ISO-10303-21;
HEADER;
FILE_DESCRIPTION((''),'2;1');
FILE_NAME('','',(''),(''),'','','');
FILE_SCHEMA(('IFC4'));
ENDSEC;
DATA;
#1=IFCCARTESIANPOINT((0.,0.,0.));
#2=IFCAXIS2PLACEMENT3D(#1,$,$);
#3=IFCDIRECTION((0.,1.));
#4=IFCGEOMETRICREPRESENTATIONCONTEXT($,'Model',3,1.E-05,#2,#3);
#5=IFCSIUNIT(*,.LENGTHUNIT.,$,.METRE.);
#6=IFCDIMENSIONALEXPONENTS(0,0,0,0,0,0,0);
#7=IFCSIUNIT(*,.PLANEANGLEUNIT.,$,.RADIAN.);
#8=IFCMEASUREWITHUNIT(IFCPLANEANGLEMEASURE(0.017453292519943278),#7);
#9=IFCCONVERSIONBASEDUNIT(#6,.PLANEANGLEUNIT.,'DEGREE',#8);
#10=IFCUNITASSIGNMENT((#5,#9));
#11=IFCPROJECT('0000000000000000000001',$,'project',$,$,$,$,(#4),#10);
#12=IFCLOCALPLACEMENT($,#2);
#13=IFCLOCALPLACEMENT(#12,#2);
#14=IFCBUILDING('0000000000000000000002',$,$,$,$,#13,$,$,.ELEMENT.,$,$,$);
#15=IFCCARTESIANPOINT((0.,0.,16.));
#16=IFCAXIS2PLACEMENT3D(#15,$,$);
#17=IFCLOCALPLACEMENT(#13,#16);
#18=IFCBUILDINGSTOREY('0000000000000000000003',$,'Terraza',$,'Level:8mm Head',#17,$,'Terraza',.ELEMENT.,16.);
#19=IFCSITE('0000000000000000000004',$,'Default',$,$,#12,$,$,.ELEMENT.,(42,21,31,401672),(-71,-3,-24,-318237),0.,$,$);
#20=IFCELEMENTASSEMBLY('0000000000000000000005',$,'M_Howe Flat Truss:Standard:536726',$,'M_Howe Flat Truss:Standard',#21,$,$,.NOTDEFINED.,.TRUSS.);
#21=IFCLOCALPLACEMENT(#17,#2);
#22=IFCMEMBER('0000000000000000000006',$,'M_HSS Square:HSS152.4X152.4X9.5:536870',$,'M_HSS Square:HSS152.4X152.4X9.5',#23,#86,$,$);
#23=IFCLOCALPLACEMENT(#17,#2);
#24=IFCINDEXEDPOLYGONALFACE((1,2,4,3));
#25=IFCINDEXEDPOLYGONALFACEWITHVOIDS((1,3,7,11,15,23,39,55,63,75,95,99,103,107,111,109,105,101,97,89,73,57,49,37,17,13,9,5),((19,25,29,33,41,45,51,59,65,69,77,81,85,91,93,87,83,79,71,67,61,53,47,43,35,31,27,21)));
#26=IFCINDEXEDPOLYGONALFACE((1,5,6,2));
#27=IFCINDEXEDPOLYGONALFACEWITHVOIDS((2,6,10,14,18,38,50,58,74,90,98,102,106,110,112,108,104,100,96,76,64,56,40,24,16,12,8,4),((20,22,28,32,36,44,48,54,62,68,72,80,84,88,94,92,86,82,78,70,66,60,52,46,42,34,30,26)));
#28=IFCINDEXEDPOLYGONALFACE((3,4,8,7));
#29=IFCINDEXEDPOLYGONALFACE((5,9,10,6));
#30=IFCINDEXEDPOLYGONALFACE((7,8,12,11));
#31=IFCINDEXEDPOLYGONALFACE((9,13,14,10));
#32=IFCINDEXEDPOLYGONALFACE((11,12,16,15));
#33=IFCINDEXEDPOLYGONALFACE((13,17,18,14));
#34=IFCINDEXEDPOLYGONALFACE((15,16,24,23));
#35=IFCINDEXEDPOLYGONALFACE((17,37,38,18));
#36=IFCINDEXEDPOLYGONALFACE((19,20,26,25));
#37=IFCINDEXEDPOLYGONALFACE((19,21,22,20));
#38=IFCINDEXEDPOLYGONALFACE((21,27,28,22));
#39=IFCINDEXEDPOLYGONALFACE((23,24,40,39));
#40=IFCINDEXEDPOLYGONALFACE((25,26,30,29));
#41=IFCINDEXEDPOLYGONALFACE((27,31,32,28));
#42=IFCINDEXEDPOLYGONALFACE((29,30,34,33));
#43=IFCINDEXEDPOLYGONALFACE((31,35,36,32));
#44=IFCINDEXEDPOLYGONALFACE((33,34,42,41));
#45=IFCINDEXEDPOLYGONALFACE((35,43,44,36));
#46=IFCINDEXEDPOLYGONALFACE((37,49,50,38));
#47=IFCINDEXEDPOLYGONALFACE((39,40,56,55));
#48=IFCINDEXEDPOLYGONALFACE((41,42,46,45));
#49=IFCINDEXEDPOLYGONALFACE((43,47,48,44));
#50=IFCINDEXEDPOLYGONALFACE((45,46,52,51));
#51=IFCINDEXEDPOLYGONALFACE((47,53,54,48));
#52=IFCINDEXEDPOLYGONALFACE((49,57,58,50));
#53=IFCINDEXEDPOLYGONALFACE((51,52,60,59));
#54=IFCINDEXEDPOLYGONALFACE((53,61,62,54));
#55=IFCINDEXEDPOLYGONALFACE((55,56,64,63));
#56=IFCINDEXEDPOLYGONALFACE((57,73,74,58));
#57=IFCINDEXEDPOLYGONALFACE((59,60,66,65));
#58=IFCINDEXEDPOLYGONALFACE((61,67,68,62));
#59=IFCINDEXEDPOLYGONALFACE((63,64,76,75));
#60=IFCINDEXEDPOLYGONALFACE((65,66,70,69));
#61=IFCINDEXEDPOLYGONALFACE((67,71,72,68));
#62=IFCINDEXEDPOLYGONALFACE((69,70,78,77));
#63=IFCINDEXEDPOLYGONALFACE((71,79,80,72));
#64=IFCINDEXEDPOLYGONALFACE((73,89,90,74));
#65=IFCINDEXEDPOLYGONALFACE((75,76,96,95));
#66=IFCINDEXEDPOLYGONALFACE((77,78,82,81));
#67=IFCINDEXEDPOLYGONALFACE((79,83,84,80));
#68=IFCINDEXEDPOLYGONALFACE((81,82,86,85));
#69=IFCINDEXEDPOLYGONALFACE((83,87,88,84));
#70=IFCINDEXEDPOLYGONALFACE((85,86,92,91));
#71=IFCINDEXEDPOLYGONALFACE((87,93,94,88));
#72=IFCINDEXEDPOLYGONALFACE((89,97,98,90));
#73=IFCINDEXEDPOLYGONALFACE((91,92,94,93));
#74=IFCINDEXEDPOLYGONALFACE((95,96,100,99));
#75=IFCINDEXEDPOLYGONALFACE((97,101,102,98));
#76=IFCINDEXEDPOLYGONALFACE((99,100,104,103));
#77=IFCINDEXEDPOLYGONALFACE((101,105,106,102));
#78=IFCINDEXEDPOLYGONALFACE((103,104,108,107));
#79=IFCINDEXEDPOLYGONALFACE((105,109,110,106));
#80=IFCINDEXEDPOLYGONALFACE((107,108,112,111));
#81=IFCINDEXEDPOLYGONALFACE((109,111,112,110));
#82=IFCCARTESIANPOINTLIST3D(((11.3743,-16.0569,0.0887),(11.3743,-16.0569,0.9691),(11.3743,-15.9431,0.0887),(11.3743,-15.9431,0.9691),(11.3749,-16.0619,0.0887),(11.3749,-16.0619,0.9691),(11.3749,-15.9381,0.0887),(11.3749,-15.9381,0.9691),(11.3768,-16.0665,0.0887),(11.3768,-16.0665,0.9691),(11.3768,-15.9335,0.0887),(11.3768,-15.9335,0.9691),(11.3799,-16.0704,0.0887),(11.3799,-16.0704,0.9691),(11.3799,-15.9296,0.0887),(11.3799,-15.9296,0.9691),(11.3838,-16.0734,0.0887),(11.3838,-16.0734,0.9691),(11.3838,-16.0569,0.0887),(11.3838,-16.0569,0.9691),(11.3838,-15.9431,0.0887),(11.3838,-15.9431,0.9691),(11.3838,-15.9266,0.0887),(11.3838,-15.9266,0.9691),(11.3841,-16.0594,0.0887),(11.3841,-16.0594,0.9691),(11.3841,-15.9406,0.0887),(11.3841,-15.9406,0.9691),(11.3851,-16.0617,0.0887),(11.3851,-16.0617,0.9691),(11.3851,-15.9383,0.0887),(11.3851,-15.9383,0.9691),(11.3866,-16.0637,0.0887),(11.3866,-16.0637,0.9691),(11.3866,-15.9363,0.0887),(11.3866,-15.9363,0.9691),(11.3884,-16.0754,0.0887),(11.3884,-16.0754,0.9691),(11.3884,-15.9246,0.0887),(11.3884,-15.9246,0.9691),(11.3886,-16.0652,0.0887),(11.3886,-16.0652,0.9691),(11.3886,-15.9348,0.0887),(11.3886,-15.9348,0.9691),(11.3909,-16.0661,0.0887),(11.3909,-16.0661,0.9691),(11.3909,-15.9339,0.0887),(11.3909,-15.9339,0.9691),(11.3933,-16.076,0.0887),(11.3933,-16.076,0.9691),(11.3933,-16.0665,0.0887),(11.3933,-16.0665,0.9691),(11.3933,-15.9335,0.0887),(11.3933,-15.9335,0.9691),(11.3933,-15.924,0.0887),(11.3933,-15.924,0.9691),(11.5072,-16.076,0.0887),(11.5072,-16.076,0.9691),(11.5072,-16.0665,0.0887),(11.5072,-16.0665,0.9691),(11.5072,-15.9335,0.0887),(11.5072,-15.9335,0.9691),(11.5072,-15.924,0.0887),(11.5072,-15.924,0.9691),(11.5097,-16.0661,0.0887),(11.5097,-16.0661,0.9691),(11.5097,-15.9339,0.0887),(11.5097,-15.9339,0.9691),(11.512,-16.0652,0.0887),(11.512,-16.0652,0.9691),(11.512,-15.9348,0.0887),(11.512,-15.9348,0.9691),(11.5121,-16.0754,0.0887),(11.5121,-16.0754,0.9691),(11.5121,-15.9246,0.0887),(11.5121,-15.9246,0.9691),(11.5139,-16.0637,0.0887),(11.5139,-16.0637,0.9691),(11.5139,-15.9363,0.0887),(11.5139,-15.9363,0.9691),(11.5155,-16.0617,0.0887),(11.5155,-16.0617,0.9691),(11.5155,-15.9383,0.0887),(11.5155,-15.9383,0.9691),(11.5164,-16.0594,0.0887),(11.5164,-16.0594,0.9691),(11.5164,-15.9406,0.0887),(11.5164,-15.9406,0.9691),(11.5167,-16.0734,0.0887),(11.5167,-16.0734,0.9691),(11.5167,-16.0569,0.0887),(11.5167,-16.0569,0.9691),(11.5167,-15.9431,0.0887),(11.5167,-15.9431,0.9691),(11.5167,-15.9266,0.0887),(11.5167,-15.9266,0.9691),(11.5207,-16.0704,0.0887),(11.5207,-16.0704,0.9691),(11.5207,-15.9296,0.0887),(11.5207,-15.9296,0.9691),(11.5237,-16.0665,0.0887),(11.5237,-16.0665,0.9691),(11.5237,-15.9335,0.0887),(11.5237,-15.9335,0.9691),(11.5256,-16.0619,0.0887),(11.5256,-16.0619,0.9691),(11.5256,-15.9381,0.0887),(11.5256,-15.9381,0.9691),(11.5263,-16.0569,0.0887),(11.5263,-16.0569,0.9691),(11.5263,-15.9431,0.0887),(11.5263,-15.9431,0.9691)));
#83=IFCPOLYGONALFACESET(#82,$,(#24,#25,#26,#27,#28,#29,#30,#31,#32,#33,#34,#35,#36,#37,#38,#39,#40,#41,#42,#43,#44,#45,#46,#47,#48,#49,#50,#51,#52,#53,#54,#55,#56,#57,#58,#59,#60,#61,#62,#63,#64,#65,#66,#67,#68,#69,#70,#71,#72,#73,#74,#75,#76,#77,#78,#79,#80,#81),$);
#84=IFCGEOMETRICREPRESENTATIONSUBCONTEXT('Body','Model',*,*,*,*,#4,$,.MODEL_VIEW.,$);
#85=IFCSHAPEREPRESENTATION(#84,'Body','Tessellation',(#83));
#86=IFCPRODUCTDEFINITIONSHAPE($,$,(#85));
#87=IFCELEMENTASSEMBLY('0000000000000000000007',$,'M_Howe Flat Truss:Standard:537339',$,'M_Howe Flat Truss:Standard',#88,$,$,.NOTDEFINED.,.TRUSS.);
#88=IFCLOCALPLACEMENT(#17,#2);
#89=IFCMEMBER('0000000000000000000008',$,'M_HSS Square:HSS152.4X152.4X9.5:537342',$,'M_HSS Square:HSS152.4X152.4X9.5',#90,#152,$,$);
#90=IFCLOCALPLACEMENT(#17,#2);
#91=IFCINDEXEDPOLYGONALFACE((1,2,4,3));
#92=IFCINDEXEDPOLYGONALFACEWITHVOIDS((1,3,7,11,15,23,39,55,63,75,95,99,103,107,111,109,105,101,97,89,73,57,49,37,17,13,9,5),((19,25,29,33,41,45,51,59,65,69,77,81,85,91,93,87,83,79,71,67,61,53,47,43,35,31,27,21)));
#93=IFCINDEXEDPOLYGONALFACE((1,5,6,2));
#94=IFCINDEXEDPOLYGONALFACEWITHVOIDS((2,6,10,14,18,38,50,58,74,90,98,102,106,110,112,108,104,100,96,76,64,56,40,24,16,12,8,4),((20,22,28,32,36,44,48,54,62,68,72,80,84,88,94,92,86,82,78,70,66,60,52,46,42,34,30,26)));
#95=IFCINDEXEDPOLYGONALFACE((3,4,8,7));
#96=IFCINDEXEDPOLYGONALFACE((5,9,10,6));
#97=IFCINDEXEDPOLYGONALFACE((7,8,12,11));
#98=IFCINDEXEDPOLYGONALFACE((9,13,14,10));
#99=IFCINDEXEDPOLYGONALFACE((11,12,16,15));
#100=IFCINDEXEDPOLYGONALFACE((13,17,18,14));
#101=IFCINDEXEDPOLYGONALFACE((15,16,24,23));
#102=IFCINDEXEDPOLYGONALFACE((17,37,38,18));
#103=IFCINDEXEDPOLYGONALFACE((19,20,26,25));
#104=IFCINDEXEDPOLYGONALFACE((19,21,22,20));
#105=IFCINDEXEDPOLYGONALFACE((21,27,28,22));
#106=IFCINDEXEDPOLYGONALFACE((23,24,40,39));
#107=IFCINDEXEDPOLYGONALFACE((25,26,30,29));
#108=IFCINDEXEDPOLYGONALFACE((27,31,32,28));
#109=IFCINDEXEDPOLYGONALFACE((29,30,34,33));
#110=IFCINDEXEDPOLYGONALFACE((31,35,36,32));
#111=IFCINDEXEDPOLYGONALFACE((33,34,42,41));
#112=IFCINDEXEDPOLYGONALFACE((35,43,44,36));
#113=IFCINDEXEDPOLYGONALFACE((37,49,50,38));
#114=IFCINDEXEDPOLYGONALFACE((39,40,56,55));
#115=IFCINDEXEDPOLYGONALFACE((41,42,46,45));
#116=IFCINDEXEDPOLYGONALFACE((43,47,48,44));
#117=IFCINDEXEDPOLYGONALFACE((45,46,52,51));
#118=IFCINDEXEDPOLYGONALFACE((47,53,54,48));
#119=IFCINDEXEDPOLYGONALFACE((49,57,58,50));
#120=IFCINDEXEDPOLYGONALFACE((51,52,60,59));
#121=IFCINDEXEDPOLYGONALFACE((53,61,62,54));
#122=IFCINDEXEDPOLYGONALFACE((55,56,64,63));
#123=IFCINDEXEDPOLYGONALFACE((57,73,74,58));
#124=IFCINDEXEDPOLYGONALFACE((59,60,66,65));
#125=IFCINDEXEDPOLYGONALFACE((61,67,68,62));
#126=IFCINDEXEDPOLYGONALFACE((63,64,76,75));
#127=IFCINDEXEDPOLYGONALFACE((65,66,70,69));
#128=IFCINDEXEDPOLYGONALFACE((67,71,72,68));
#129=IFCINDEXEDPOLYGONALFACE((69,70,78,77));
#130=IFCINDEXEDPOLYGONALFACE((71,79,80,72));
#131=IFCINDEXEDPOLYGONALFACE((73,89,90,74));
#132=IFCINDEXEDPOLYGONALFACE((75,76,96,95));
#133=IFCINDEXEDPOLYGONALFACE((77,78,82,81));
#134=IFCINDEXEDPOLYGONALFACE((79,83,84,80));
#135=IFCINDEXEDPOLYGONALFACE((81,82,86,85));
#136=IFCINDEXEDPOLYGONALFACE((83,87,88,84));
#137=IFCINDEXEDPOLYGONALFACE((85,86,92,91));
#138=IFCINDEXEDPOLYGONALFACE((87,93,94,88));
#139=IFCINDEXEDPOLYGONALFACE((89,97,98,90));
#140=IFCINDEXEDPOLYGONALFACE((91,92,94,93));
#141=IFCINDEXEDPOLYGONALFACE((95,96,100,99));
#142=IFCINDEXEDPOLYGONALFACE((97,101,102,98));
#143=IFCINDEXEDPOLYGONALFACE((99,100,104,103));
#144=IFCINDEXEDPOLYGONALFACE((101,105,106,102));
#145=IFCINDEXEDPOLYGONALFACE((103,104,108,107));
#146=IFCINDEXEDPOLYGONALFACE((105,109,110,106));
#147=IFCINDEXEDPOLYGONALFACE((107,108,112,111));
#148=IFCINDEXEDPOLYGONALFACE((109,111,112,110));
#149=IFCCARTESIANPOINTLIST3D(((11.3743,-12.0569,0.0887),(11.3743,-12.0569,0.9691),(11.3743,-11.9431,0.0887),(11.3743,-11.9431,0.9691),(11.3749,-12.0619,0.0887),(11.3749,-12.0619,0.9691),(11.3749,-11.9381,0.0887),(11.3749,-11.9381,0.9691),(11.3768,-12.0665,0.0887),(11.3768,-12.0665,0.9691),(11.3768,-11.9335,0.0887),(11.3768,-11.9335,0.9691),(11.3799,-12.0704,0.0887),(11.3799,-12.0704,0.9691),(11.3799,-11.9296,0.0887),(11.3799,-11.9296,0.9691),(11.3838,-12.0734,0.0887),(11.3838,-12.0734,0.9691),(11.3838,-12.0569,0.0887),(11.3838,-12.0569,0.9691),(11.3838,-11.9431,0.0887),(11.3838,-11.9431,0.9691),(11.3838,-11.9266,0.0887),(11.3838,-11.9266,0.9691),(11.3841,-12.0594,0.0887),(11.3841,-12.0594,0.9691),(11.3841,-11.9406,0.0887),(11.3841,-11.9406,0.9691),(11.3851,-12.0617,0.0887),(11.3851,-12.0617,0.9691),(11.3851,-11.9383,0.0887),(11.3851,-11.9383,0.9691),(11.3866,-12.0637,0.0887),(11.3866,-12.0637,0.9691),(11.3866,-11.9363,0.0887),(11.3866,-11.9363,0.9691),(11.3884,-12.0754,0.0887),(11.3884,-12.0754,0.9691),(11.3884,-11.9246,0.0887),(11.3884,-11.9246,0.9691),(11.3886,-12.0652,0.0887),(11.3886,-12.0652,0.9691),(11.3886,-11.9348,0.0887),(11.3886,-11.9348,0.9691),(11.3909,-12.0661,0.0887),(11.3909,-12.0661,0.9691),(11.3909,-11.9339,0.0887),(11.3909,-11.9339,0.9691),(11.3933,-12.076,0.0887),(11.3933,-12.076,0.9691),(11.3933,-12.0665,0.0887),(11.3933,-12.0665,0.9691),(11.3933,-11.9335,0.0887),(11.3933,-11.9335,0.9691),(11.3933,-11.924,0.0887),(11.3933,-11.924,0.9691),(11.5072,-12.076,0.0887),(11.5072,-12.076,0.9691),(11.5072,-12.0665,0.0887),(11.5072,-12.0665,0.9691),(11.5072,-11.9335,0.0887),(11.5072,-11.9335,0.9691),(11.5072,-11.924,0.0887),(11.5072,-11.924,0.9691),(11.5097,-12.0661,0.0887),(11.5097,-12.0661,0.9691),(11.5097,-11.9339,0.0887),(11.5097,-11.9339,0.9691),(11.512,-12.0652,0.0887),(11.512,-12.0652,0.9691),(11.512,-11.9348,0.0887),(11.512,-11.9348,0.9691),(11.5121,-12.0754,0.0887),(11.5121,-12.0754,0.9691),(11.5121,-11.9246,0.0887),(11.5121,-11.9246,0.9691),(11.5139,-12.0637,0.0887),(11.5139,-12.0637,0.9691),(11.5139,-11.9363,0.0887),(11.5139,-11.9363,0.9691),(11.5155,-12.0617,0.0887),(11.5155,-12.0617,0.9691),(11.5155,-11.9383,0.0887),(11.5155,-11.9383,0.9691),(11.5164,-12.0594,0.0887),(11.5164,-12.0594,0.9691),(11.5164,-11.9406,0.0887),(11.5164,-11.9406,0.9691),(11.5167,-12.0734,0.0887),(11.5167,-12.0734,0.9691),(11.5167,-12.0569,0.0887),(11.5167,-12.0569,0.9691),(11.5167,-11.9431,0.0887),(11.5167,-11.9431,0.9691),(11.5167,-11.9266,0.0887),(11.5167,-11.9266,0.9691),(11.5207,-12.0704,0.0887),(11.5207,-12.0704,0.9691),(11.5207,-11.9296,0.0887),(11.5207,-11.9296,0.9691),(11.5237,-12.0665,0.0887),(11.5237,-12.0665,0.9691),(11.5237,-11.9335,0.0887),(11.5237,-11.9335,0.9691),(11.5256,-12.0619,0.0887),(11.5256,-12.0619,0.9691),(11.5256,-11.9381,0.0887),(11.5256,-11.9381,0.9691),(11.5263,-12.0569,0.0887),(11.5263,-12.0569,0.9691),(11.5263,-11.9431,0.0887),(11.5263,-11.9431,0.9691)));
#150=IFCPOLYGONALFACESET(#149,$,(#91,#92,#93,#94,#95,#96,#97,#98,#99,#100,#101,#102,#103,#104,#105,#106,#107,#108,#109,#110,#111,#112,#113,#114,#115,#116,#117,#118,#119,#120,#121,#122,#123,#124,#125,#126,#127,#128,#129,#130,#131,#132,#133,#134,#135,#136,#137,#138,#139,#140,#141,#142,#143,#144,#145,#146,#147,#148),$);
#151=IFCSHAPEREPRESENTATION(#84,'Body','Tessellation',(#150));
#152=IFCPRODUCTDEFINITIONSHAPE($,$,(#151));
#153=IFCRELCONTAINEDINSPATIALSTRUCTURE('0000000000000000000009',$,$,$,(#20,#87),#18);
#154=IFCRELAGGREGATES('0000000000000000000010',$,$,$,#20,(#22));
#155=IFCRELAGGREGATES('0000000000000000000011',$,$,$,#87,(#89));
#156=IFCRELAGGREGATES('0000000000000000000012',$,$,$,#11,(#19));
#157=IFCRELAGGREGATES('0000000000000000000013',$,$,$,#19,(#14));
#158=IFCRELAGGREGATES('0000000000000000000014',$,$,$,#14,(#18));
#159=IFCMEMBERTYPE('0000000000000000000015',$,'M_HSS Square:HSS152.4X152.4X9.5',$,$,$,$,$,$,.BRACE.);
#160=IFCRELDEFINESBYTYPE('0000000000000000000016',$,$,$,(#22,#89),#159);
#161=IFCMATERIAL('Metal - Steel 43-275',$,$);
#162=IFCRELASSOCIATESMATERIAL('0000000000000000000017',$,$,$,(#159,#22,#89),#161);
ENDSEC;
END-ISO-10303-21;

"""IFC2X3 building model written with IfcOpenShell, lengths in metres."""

from ifc_helpers import new_model, entity, si_unit, converted_unit, direction, frame, frame_2d, origin, place, context, subcontext, project, spatial, polyline, circle_curve, parameter, trimmed, segment, composite_curve, outline, extrude, source, transform, mapped, material, type_object, type_shapes, element, aggregate, save


model = new_model("IFC2X3")

# Units and contexts
model_context = context("Model", 3, precision=1e-05, world=origin(), true_north=direction((0.0, 1.0)))
body_context = subcontext(model_context, "Body", "Model", "MODEL_VIEW")
ifc_project = project(units=[si_unit("LENGTHUNIT", "METRE"), converted_unit("PLANEANGLEUNIT", "DEGREE", entity("IfcPlaneAngleMeasure", 0.017453292519943278), si_unit("PLANEANGLEUNIT", "RADIAN"), dimensions=[0, 0, 0, 0, 0, 0, 0])], contexts=[model_context])

# Site, building, storey
site_placement = place(None, origin())
site = spatial("IfcSite", under=ifc_project, at=site_placement, Name="Default", CompositionType="ELEMENT", RefLatitude=(42, 21, 31, 401672), RefLongitude=(-71, -3, -24, -318237), RefElevation=0.0)
building_placement = place(site_placement, origin())
building = spatial("IfcBuilding", under=site, at=building_placement, CompositionType="ELEMENT")
storey_placement = place(building_placement, frame((0.0, 0.0, 16.0)))
storey = spatial("IfcBuildingStorey", under=building, at=storey_placement, Name="Terraza", ObjectType="Level:8mm Head", LongName="Terraza", CompositionType="ELEMENT", Elevation=16.0)

# Element assemblies, members
assembly_1_placement = place(storey_placement, origin())
assembly_1 = element("IfcElementAssembly", 1, at=assembly_1_placement, inside=storey, Name="M_Howe Flat Truss:Standard:536726", ObjectType="M_Howe Flat Truss:Standard", AssemblyPlace="NOTDEFINED", PredefinedType="TRUSS")
ifc_material = material(Name="Metal - Steel 43-275")
member_type_1 = type_object("IfcMemberType", Name="M_HSS Square:HSS152.4X152.4X9.5", PredefinedType="BRACE", material=ifc_material)
shared_shape_1 = source(origin(), body_context, "Body", "SweptSolid", [
    extrude(outline(composite_curve([segment(polyline([(-0.0569, -0.076), (0.0569, -0.076)]), True, "CONTINUOUS"), segment(trimmed(circle_curve(frame_2d((0.0569, -0.0569), x_axis=(0.0, 1.0)), 0.0191), [parameter(180.0)], [parameter(270.0)], True, "PARAMETER"), True, "CONTINUOUS"), segment(polyline([(0.076, -0.0569), (0.076, 0.0569)]), True, "CONTINUOUS"), segment(trimmed(circle_curve(frame_2d((0.0569, 0.0569), x_axis=(0.0, 1.0)), 0.0191), [parameter(270.0)], [parameter(0.0)], True, "PARAMETER"), True, "CONTINUOUS"), segment(polyline([(0.0569, 0.076), (-0.0569, 0.076)]), True, "CONTINUOUS"), segment(trimmed(circle_curve(frame_2d((-0.0569, 0.0569), x_axis=(0.0, 1.0)), 0.0191), [parameter(0.0)], [parameter(90.0)], True, "PARAMETER"), True, "CONTINUOUS"), segment(polyline([(-0.076, 0.0569), (-0.076, -0.0569)]), True, "CONTINUOUS"), segment(trimmed(circle_curve(frame_2d((-0.0569, -0.0569), x_axis=(0.0, 1.0)), 0.0191), [parameter(90.0)], [parameter(180.0)], True, "PARAMETER"), True, "CONTINUOUS")], self_intersect=False), holes=[composite_curve([segment(trimmed(circle_curve(frame_2d((-0.0569, 0.0569), x_axis=(0.0, 1.0)), 0.0095), [parameter(360.0)], [parameter(90.0)], True, "PARAMETER"), False, "CONTINUOUS"), segment(polyline([(-0.0569, 0.0665), (0.0569, 0.0665)]), True, "CONTINUOUS"), segment(trimmed(circle_curve(frame_2d((0.0569, 0.0569), x_axis=(0.0, 1.0)), 0.0095), [parameter(270.0)], [parameter(360.0)], True, "PARAMETER"), False, "CONTINUOUS"), segment(polyline([(0.0665, 0.0569), (0.0665, -0.0569)]), True, "CONTINUOUS"), segment(trimmed(circle_curve(frame_2d((0.0569, -0.0569), x_axis=(0.0, 1.0)), 0.0095), [parameter(180.0)], [parameter(270.0)], True, "PARAMETER"), False, "CONTINUOUS"), segment(polyline([(0.0569, -0.0665), (-0.0569, -0.0665)]), True, "CONTINUOUS"), segment(trimmed(circle_curve(frame_2d((-0.0569, -0.0569), x_axis=(0.0, 1.0)), 0.0095), [parameter(90.0)], [parameter(180.0)], True, "PARAMETER"), False, "CONTINUOUS"), segment(polyline([(-0.0665, -0.0569), (-0.0665, 0.0569)]), True, "CONTINUOUS")], self_intersect=False)]), frame((-0.4426, 0.0, 0.0), z_axis=(1.0, 0.0, 0.0), x_axis=(0.0, 0.0, -1.0)), (0.0, 0.0, 1.0), 0.8804),
])
type_shapes(member_type_1, [shared_shape_1])
member_1_placement = place(assembly_1_placement, frame((11.4503, -16.0, 0.5312), z_axis=(1.0, 0.0, 0.0), x_axis=(0.0, 0.0, 1.0)))
member_1 = element("IfcMember", 2, at=member_1_placement, type_object=member_type_1, material=ifc_material, Name="M_HSS Square:HSS152.4X152.4X9.5:536870", ObjectType="M_HSS Square:HSS152.4X152.4X9.5", context=body_context, shape_type="MappedRepresentation", body=[
    mapped(shared_shape_1, transform((0.0, 0.0, 0.0), scale=1.0)),
])
assembly_2_placement = place(storey_placement, origin())
assembly_2 = element("IfcElementAssembly", 3, at=assembly_2_placement, inside=storey, Name="M_Howe Flat Truss:Standard:537339", ObjectType="M_Howe Flat Truss:Standard", AssemblyPlace="NOTDEFINED", PredefinedType="TRUSS")
member_2_placement = place(assembly_2_placement, frame((11.4503, -12.0, 0.5312), z_axis=(1.0, 0.0, 0.0), x_axis=(0.0, 0.0, 1.0)))
member_2 = element("IfcMember", 4, at=member_2_placement, type_object=member_type_1, material=ifc_material, Name="M_HSS Square:HSS152.4X152.4X9.5:537342", ObjectType="M_HSS Square:HSS152.4X152.4X9.5", context=body_context, shape_type="MappedRepresentation", body=[
    mapped(shared_shape_1, transform((0.0, 0.0, 0.0), scale=1.0)),
])

aggregate(assembly_1, [member_1])
aggregate(assembly_2, [member_2])

save(model, "model.ifc")
